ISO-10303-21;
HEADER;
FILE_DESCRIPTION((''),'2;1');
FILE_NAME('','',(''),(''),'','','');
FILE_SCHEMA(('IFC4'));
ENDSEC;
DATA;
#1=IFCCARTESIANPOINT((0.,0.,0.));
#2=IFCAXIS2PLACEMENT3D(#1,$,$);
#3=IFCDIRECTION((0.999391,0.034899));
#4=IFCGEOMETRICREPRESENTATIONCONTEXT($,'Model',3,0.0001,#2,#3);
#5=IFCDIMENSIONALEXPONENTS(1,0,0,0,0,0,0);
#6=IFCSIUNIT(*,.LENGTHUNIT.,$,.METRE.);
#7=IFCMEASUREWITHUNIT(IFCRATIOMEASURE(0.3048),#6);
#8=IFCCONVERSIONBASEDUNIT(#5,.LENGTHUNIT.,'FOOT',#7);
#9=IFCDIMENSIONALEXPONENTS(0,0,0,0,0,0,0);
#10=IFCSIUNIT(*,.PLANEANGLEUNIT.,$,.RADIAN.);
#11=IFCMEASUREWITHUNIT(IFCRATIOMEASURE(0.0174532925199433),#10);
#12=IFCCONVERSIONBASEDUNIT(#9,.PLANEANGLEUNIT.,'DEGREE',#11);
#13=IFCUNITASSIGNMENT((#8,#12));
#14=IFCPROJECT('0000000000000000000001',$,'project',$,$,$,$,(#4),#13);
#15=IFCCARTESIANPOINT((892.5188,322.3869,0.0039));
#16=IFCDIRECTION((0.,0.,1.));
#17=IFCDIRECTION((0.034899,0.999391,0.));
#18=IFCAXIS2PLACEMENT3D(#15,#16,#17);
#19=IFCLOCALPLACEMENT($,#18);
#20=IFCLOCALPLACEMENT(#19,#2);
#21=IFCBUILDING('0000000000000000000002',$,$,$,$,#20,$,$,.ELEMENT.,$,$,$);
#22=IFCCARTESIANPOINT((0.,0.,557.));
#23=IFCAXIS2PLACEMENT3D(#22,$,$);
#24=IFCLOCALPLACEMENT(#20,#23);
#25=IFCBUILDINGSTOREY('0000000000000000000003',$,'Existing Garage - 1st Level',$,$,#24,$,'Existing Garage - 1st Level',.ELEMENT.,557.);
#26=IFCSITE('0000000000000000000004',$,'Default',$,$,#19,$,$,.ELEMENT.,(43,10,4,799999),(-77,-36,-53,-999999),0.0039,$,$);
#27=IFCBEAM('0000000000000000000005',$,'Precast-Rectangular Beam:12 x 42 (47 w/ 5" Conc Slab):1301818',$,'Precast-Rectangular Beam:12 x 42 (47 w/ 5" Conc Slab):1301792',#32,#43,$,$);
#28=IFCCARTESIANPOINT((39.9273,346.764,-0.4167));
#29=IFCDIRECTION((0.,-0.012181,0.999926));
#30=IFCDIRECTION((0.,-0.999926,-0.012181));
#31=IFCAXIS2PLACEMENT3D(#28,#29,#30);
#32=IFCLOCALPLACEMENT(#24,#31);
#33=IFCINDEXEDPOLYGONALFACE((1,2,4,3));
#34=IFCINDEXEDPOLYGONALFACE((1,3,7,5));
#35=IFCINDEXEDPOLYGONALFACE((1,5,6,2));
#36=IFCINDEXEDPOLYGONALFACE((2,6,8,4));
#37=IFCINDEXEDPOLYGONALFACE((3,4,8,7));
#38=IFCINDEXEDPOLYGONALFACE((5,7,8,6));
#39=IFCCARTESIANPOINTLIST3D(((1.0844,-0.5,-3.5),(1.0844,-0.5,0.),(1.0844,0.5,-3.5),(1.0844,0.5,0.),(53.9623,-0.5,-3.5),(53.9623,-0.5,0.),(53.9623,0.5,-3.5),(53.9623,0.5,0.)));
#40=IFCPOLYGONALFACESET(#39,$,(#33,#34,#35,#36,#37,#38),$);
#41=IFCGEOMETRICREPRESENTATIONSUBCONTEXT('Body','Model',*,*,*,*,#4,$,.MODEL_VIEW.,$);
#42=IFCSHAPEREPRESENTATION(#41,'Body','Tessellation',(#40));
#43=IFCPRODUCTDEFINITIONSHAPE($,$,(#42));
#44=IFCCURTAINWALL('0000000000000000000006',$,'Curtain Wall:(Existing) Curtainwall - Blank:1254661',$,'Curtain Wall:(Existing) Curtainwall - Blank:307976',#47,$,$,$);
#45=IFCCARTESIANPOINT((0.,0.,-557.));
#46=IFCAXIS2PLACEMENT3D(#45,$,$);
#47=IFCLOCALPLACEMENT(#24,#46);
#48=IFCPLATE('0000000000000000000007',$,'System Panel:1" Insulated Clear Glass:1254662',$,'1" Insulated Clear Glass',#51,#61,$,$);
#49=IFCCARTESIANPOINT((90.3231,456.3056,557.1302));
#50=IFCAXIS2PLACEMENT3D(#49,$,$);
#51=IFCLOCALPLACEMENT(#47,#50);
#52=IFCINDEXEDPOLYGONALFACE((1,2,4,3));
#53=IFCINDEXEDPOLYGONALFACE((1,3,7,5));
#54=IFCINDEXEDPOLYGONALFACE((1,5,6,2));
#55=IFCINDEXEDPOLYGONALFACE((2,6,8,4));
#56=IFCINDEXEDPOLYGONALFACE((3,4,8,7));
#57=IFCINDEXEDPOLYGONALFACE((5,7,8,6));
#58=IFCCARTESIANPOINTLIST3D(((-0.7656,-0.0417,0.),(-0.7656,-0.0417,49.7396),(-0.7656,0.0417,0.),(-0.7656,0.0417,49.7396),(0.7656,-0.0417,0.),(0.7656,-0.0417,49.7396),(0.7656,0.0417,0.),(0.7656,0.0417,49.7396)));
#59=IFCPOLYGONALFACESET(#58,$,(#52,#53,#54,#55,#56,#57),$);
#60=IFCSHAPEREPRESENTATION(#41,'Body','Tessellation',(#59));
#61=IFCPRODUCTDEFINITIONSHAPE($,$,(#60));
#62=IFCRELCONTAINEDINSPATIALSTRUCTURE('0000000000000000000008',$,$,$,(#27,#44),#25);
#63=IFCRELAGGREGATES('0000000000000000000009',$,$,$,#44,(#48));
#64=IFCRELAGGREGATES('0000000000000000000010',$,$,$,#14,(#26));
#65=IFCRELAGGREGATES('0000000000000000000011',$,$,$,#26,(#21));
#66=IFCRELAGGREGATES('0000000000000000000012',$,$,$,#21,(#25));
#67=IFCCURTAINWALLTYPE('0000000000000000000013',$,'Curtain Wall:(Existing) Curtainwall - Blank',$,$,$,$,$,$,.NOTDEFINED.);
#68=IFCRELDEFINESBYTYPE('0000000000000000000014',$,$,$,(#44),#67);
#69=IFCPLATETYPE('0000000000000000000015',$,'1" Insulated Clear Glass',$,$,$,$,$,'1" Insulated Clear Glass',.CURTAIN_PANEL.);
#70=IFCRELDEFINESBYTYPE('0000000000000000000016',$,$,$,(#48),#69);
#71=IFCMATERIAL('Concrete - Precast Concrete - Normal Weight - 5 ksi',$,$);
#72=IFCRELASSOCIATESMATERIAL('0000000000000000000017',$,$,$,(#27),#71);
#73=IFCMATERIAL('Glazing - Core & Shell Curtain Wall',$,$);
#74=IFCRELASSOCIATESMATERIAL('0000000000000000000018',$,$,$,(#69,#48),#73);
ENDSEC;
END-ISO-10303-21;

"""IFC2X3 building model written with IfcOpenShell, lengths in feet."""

from ifc_helpers import new_model, entity, si_unit, converted_unit, direction, frame, frame_2d, origin, origin_2d_with_axis, place, context, subcontext, project, spatial, rectangle, extrude, source, transform, mapped, material, type_object, type_shapes, element, aggregate, save


model = new_model("IFC2X3")

# Units and contexts
model_context = context("Model", 3, precision=0.0001, world=origin(), true_north=direction((0.999391, 0.034899)))
body_context = subcontext(model_context, "Body", "Model", "MODEL_VIEW")
ifc_project = project(units=[converted_unit("LENGTHUNIT", "FOOT", entity("IfcRatioMeasure", 0.3048), si_unit("LENGTHUNIT", "METRE"), dimensions=[1, 0, 0, 0, 0, 0, 0]), converted_unit("PLANEANGLEUNIT", "DEGREE", entity("IfcRatioMeasure", 0.0174532925199433), si_unit("PLANEANGLEUNIT", "RADIAN"), dimensions=[0, 0, 0, 0, 0, 0, 0])], contexts=[model_context])

# Site, building, storey
site_placement = place(None, frame((892.5188, 322.3869, 0.0039), z_axis=(0.0, 0.0, 1.0), x_axis=(0.034899, 0.999391, 0.0)))
site = spatial("IfcSite", under=ifc_project, at=site_placement, Name="Default", CompositionType="ELEMENT", RefLatitude=(43, 10, 4, 799999), RefLongitude=(-77, -36, -53, -999999), RefElevation=0.0039)
building_placement = place(site_placement, origin())
building = spatial("IfcBuilding", under=site, at=building_placement, CompositionType="ELEMENT")
storey_placement = place(building_placement, frame((0.0, 0.0, 557.0)))
storey = spatial("IfcBuildingStorey", under=building, at=storey_placement, Name="Existing Garage - 1st Level", LongName="Existing Garage - 1st Level", CompositionType="ELEMENT", Elevation=557.0)

# Beam
ifc_material_1 = material(Name="Concrete - Precast Concrete - Normal Weight - 5 ksi")
beam_1_placement = place(storey_placement, frame((39.9273, 346.764, -0.4167), z_axis=(0.0, -0.012181, 0.999926), x_axis=(0.0, -0.999926, -0.012181)))
element("IfcBeam", 1, at=beam_1_placement, inside=storey, material=ifc_material_1, Name="Precast-Rectangular Beam:12 x 42 (47 w/ 5\" Conc Slab):1301818", ObjectType="Precast-Rectangular Beam:12 x 42 (47 w/ 5\" Conc Slab):1301792", context=body_context, shape_type="SweptSolid", body=[
    extrude(rectangle(XDim=3.5, YDim=1.0, at=frame_2d((0.0, 0.0), x_axis=(1.0, 0.0))), frame((1.0844, 0.0, -1.75), z_axis=(1.0, 0.0, 0.0), x_axis=(0.0, 0.0, -1.0)), (0.0, 0.0, 1.0), 52.878),
])

# Curtain wall, plate
curtain_wall_type = type_object("IfcCurtainWallType", Name="Curtain Wall:(Existing) Curtainwall - Blank", PredefinedType="NOTDEFINED")
curtain_wall_placement = place(storey_placement, frame((0.0, 0.0, -557.0)))
curtain_wall = element("IfcCurtainWall", 2, at=curtain_wall_placement, inside=storey, type_object=curtain_wall_type, Name="Curtain Wall:(Existing) Curtainwall - Blank:1254661", ObjectType="Curtain Wall:(Existing) Curtainwall - Blank:307976")
ifc_material_2 = material(Name="Glazing - Core & Shell Curtain Wall")
plate_type = type_object("IfcPlateType", Name="1\" Insulated Clear Glass", ElementType="1\" Insulated Clear Glass", PredefinedType="CURTAIN_PANEL", material=ifc_material_2)
shared_shape = source(origin(), body_context, "Body", "SweptSolid", [
    extrude(rectangle(XDim=0.0833, YDim=1.5313, at=origin_2d_with_axis()), frame((0.0, 0.0, 0.0), z_axis=(0.0, 0.0, 1.0), x_axis=(0.0, 1.0, 0.0)), (0.0, 0.0, 1.0), 49.7396),
])
type_shapes(plate_type, [shared_shape])
plate_placement = place(curtain_wall_placement, frame((90.3231, 456.3056, 557.1302)))
plate = element("IfcPlate", 3, at=plate_placement, type_object=plate_type, material=ifc_material_2, Name="System Panel:1\" Insulated Clear Glass:1254662", ObjectType="1\" Insulated Clear Glass", context=body_context, shape_type="MappedRepresentation", body=[
    mapped(shared_shape, transform((0.0, 0.0, 0.0), scale=1.0)),
])
aggregate(curtain_wall, [plate])

save(model, "model.ifc")
